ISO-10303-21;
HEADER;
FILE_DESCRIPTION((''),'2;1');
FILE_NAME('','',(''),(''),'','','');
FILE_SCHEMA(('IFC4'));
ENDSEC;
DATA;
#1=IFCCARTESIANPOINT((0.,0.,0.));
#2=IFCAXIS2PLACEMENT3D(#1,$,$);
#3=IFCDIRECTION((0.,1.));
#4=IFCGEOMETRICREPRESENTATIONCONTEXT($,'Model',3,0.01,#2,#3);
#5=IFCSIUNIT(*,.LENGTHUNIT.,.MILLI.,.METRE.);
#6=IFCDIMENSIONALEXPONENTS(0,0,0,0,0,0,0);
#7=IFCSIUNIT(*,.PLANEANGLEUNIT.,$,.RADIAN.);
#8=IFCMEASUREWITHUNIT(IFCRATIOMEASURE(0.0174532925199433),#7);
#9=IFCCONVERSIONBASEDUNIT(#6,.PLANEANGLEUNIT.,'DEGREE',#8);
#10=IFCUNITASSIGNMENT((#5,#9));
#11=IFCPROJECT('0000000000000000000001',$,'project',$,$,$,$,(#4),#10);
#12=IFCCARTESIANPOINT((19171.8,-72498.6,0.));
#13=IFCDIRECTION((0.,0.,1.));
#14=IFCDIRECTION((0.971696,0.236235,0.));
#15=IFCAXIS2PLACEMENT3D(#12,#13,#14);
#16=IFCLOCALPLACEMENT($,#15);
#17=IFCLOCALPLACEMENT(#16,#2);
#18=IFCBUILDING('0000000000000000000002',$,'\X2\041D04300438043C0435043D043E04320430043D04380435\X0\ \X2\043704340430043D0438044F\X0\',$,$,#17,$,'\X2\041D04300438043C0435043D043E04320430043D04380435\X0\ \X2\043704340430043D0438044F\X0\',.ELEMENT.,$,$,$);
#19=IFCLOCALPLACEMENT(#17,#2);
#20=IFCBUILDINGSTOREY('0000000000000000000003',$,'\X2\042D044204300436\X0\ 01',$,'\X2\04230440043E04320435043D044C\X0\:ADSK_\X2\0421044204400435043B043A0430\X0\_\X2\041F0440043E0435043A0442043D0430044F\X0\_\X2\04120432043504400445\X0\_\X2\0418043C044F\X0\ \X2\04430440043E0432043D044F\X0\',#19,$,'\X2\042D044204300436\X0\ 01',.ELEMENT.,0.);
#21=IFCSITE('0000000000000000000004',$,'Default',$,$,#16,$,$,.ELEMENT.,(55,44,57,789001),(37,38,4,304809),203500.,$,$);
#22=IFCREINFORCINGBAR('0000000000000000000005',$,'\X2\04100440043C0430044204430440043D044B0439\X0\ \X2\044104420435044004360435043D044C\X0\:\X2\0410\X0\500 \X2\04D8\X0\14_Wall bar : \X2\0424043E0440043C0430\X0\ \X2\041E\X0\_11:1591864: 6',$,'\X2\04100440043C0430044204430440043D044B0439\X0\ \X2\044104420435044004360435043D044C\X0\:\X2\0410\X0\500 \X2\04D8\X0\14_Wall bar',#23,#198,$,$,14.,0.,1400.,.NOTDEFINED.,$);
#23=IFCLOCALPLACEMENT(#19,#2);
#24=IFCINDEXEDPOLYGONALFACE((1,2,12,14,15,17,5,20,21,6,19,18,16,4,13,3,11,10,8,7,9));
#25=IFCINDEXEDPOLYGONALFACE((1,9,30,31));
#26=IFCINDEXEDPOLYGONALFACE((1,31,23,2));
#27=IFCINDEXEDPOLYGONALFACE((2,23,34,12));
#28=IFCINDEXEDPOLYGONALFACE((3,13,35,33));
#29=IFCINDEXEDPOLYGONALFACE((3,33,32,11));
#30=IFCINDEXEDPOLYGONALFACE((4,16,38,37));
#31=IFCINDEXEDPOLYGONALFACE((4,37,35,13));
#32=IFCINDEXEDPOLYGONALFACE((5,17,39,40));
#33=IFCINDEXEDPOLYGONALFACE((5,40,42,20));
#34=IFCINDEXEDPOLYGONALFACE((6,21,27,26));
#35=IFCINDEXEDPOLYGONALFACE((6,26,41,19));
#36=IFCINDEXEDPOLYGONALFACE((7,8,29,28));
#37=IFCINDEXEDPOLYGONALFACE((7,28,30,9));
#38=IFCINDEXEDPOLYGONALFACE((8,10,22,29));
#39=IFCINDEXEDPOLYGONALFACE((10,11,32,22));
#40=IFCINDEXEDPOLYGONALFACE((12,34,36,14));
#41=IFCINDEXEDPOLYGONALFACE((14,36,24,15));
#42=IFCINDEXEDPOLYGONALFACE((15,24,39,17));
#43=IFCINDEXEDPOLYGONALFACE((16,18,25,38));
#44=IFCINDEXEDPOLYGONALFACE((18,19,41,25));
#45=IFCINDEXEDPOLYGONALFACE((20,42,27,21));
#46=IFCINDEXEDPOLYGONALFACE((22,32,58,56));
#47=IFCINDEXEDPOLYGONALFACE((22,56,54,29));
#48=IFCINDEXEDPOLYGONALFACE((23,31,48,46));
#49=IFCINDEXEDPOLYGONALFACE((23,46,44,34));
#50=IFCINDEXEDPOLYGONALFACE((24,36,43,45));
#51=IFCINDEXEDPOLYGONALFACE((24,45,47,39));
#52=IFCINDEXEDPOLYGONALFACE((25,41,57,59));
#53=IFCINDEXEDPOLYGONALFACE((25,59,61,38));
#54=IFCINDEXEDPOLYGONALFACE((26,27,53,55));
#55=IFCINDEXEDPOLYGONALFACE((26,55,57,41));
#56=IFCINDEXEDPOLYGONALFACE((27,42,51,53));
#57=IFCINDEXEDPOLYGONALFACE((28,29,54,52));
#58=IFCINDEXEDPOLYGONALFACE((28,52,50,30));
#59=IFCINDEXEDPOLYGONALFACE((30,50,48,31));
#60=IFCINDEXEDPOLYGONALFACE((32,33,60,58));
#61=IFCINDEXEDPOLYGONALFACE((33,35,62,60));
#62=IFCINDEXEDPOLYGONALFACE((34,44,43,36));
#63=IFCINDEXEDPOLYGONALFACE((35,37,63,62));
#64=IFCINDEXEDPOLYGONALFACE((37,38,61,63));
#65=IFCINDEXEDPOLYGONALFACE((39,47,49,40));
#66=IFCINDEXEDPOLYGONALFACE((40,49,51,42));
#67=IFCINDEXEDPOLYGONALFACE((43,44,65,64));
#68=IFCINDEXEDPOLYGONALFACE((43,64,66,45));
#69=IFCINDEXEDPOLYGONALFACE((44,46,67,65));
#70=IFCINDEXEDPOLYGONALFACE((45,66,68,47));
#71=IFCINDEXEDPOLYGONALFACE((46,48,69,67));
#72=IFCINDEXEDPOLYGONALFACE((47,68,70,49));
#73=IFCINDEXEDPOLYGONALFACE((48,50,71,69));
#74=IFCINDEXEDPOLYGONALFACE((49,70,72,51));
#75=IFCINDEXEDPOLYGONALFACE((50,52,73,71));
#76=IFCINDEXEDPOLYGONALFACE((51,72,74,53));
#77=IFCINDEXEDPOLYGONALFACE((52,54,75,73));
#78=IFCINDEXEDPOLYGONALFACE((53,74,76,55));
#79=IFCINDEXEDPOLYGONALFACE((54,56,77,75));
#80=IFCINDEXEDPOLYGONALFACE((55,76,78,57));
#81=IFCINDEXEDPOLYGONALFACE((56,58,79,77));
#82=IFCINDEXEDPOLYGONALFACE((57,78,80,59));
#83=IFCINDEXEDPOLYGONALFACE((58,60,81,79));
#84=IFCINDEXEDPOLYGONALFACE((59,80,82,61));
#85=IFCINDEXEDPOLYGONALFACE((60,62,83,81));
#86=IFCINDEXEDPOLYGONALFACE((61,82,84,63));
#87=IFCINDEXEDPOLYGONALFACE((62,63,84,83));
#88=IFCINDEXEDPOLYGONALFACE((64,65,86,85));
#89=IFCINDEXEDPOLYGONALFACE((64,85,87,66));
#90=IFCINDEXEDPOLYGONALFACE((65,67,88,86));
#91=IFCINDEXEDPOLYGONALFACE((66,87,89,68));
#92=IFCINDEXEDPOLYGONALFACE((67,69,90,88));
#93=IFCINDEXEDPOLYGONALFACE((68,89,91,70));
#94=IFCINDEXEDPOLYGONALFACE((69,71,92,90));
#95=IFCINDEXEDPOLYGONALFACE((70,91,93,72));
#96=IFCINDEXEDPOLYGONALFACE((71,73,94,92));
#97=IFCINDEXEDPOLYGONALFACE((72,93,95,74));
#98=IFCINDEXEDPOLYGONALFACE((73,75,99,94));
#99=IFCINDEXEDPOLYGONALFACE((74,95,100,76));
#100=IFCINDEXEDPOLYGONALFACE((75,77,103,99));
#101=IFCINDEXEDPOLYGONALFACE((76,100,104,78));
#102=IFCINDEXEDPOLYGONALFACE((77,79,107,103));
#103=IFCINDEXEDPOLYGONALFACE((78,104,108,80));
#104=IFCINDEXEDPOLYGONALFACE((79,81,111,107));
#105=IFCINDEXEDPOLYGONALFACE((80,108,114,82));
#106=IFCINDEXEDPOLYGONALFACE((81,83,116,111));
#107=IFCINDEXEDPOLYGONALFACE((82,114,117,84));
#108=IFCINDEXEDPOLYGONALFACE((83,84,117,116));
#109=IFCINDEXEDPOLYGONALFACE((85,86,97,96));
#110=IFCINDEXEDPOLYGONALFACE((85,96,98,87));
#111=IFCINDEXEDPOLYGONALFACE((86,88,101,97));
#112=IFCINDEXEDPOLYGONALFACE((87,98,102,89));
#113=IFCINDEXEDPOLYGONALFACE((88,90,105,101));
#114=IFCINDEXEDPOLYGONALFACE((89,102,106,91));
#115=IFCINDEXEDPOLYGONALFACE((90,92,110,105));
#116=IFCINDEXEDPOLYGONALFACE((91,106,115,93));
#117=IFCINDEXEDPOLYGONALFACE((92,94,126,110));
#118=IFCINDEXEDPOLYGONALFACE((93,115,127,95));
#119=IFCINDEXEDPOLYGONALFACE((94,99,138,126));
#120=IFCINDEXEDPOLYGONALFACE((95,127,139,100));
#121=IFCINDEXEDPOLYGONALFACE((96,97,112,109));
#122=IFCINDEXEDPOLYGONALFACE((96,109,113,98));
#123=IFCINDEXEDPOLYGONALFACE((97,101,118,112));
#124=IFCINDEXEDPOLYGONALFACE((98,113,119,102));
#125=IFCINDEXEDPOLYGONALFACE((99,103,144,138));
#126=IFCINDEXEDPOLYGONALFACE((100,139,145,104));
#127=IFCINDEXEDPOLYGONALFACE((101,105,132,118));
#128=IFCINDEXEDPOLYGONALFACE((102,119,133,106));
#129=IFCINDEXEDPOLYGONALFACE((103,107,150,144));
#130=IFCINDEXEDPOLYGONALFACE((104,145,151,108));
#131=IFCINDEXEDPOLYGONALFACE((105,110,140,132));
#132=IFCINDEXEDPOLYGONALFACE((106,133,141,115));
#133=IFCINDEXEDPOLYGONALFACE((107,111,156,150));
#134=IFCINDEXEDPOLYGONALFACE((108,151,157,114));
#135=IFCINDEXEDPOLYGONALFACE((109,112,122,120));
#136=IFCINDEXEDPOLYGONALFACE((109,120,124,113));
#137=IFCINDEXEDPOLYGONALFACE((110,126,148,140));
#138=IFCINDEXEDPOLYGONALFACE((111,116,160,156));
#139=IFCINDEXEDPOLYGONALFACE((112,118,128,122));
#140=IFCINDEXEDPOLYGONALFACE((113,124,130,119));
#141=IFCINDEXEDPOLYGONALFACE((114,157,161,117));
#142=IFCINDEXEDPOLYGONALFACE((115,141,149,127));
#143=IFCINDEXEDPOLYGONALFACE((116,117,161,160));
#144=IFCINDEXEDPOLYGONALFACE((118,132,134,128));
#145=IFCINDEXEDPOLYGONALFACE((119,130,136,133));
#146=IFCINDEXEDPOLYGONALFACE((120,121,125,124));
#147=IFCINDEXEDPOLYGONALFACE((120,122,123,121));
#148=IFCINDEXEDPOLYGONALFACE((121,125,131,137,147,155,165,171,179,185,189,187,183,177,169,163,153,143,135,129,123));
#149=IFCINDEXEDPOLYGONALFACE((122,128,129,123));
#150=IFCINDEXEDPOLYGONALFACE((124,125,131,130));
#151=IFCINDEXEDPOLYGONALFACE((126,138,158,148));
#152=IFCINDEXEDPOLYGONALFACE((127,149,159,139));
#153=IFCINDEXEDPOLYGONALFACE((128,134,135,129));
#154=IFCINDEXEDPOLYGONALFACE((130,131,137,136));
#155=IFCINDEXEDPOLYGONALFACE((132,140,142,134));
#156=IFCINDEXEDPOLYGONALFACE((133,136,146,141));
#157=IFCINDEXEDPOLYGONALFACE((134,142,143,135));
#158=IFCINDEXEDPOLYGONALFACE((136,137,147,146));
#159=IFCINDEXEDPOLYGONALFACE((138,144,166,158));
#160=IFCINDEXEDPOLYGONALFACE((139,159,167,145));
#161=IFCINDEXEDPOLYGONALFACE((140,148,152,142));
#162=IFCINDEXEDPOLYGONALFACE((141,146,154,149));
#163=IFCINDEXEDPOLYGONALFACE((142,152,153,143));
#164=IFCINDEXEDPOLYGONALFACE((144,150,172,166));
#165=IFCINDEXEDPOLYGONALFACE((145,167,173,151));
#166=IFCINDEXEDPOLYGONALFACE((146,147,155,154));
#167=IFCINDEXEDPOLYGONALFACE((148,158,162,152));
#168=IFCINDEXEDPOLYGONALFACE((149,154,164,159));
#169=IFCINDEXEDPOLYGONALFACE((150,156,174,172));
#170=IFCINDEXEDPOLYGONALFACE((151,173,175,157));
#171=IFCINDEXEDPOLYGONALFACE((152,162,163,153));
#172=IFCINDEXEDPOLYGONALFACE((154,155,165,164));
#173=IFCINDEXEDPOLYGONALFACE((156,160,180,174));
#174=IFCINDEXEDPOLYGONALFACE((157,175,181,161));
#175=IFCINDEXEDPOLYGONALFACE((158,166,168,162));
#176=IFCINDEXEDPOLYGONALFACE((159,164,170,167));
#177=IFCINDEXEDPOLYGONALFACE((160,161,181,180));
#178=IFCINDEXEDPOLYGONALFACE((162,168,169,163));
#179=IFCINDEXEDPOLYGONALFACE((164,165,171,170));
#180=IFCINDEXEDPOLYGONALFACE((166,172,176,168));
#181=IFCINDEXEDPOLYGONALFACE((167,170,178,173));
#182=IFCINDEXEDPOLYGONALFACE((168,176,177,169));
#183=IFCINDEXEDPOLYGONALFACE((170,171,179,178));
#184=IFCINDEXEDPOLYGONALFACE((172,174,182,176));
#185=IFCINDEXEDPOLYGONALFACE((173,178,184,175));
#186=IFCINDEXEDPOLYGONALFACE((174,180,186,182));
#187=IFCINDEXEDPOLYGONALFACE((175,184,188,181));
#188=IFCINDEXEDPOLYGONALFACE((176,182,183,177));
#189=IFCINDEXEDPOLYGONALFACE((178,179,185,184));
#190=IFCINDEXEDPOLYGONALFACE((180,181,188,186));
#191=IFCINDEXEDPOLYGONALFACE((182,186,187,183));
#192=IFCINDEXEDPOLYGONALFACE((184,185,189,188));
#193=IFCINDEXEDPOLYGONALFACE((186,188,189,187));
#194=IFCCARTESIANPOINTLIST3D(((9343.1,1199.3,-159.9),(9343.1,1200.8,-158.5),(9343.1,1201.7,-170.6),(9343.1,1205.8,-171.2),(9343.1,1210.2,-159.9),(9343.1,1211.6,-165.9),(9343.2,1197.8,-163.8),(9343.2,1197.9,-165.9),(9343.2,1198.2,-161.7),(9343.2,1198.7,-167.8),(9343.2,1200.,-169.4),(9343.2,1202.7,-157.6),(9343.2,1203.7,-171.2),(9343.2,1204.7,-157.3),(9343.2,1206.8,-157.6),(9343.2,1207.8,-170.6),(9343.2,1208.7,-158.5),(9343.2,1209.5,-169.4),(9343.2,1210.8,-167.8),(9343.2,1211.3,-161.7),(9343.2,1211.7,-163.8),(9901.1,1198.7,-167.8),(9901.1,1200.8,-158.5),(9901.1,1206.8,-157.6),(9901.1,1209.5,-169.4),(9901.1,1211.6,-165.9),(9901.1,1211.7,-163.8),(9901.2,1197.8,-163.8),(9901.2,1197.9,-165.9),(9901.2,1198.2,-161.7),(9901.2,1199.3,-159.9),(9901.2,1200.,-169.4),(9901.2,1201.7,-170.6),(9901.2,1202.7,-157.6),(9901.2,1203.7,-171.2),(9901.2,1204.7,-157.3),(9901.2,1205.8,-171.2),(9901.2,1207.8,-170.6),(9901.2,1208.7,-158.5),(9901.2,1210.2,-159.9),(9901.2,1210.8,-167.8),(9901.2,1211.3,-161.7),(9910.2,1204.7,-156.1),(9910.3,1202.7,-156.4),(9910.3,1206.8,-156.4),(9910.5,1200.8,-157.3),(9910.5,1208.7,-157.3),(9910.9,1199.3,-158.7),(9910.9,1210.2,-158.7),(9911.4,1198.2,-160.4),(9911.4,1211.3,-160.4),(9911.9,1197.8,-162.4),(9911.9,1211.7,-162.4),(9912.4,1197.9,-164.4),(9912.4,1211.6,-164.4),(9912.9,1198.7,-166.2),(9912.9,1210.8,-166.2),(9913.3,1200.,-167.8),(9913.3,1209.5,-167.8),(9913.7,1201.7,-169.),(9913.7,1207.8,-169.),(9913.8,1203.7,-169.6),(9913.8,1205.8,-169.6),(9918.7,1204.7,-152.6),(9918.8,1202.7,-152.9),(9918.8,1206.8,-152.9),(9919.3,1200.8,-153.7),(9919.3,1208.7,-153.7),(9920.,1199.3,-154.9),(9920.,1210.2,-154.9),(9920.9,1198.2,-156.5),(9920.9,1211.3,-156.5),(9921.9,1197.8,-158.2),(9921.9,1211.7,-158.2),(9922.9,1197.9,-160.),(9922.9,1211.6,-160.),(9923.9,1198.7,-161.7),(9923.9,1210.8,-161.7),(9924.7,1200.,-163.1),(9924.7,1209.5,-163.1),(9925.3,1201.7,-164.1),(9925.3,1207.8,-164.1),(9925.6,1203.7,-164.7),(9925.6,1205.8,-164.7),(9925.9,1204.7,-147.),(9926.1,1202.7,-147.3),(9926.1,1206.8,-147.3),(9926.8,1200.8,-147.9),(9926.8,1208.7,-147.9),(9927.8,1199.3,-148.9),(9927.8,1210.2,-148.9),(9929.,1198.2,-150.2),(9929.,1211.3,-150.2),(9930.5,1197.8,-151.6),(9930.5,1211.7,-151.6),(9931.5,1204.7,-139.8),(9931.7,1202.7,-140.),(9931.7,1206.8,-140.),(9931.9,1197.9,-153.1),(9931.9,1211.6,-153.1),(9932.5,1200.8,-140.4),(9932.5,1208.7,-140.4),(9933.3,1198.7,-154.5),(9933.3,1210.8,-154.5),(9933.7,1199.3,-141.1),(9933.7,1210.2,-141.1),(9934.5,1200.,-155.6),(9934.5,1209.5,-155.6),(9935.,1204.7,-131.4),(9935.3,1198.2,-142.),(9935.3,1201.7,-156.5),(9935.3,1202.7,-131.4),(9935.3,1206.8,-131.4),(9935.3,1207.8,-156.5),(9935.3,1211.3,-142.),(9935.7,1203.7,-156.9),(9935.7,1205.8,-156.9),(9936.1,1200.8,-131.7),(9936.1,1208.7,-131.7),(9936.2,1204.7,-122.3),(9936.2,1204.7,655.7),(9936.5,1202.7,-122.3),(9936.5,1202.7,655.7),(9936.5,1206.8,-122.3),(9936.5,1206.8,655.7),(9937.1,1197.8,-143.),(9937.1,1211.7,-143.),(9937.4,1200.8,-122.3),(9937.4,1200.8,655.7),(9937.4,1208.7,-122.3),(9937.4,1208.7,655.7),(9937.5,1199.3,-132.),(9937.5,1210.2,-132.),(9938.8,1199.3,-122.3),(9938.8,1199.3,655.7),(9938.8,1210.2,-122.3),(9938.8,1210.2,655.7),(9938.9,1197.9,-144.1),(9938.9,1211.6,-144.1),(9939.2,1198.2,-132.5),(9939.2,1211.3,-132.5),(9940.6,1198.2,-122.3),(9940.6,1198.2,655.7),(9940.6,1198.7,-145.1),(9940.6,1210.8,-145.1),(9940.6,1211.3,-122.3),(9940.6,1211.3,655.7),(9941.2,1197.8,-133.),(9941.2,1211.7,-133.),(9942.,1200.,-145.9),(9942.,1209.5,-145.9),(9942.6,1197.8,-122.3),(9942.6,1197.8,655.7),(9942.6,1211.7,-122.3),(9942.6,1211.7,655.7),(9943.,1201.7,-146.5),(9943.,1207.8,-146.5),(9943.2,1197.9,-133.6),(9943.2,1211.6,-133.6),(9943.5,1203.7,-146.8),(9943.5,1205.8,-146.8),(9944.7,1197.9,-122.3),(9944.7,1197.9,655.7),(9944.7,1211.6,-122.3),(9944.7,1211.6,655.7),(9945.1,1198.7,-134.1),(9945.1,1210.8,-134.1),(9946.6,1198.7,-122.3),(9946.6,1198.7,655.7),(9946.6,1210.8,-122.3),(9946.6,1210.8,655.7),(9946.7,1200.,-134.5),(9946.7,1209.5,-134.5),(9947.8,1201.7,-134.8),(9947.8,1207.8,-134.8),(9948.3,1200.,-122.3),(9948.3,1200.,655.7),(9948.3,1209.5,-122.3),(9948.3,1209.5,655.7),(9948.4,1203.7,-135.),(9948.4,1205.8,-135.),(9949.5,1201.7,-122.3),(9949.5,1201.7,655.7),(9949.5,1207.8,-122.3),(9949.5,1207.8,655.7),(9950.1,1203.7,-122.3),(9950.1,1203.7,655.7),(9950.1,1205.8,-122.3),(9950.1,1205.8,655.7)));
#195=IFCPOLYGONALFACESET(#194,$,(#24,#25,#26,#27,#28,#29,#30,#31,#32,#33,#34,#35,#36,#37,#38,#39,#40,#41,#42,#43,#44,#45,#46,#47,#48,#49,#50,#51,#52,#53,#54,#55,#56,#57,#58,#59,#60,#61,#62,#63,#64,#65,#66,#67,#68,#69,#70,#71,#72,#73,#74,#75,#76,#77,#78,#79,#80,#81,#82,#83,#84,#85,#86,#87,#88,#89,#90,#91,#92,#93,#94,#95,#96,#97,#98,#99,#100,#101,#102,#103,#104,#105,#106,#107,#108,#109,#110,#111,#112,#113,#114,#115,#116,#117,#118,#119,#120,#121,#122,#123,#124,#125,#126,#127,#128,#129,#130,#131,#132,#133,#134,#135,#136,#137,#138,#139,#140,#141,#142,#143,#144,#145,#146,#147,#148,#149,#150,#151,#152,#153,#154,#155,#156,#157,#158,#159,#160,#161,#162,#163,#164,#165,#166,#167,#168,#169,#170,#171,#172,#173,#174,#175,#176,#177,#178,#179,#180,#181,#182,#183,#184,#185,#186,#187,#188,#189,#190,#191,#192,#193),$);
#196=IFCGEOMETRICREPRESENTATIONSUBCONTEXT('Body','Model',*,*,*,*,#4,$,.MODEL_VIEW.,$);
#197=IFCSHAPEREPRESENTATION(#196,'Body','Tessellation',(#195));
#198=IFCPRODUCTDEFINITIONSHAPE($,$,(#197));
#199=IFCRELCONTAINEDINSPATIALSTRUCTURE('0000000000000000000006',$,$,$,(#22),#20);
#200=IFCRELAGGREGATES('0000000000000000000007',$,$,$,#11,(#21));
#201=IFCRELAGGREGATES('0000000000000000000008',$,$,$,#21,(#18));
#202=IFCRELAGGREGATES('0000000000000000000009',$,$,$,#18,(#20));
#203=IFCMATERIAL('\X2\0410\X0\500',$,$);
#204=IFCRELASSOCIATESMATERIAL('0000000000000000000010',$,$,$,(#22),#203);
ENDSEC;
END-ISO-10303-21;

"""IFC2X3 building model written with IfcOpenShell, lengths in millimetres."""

from ifc_helpers import new_model, entity, si_unit, converted_unit, direction, frame, origin, place, context, subcontext, project, spatial, material, element, save


model = new_model("IFC2X3")

# Units and contexts
model_context = context("Model", 3, precision=0.01, world=origin(), true_north=direction((0.0, 1.0)))
body_context = subcontext(model_context, "Body", "Model", "MODEL_VIEW")
ifc_project = project(units=[si_unit("LENGTHUNIT", "METRE", prefix="MILLI"), converted_unit("PLANEANGLEUNIT", "DEGREE", entity("IfcRatioMeasure", 0.0174532925199433), si_unit("PLANEANGLEUNIT", "RADIAN"), dimensions=[0, 0, 0, 0, 0, 0, 0])], contexts=[model_context])

# Site, building, storey
site_placement = place(None, frame((19171.8, -72498.6, 0.0), z_axis=(0.0, 0.0, 1.0), x_axis=(0.971696, 0.236235, 0.0)))
site = spatial("IfcSite", under=ifc_project, at=site_placement, Name="Default", CompositionType="ELEMENT", RefLatitude=(55, 44, 57, 789001), RefLongitude=(37, 38, 4, 304809), RefElevation=203500.0)
building_placement = place(site_placement, origin())
building = spatial("IfcBuilding", under=site, at=building_placement, Name="Наименование здания", LongName="Наименование здания", CompositionType="ELEMENT")
storey_placement = place(building_placement, origin())
storey = spatial("IfcBuildingStorey", under=building, at=storey_placement, Name="Этаж 01", ObjectType="Уровень:ADSK_Стрелка_Проектная_Вверх_Имя уровня", LongName="Этаж 01", CompositionType="ELEMENT", Elevation=0.0)

# Reinforcing bar
ifc_material = material(Name="А500")
placement = place(storey_placement, origin())
element("IfcReinforcingBar", 1, at=placement, inside=storey, material=ifc_material, Name="Арматурный стержень:А500 Ә14_Wall bar : Форма О_11:1591864: 6", ObjectType="Арматурный стержень:А500 Ә14_Wall bar", BarLength=1400.0, BarRole="NOTDEFINED", CrossSectionArea=0.0, NominalDiameter=14.0, context=body_context, shape_type="AdvancedSweptSolid", body=[
    entity("IfcSweptDiskSolid", entity("IfcCompositeCurve", [entity("IfcCompositeCurveSegment", "CONTINUOUS", True, entity("IfcPolyline", [entity("IfcCartesianPoint", [9943.1, 1204.7, 655.7]), entity("IfcCartesianPoint", [9943.1, 1204.7, -122.3])])), entity("IfcCompositeCurveSegment", "CONTINUOUS", True, entity("IfcTrimmedCurve", entity("IfcCircle", entity("IfcAxis2Placement3D", entity("IfcCartesianPoint", [9901.1, 1204.7, -122.3]), entity("IfcDirection", [0.0, 1.0, 0.0]), entity("IfcDirection", [0.0, 0.0, -1.0])), 42.0), [entity("IfcParameterValue", 270.0)], [entity("IfcParameterValue", 360.0)], True, "PARAMETER")), entity("IfcCompositeCurveSegment", "CONTINUOUS", True, entity("IfcPolyline", [entity("IfcCartesianPoint", [9901.1, 1204.7, -164.3]), entity("IfcCartesianPoint", [9343.1, 1204.7, -164.3])]))], False), 7.0, None, 0.0, 92.0),
])

save(model, "model.ifc")
